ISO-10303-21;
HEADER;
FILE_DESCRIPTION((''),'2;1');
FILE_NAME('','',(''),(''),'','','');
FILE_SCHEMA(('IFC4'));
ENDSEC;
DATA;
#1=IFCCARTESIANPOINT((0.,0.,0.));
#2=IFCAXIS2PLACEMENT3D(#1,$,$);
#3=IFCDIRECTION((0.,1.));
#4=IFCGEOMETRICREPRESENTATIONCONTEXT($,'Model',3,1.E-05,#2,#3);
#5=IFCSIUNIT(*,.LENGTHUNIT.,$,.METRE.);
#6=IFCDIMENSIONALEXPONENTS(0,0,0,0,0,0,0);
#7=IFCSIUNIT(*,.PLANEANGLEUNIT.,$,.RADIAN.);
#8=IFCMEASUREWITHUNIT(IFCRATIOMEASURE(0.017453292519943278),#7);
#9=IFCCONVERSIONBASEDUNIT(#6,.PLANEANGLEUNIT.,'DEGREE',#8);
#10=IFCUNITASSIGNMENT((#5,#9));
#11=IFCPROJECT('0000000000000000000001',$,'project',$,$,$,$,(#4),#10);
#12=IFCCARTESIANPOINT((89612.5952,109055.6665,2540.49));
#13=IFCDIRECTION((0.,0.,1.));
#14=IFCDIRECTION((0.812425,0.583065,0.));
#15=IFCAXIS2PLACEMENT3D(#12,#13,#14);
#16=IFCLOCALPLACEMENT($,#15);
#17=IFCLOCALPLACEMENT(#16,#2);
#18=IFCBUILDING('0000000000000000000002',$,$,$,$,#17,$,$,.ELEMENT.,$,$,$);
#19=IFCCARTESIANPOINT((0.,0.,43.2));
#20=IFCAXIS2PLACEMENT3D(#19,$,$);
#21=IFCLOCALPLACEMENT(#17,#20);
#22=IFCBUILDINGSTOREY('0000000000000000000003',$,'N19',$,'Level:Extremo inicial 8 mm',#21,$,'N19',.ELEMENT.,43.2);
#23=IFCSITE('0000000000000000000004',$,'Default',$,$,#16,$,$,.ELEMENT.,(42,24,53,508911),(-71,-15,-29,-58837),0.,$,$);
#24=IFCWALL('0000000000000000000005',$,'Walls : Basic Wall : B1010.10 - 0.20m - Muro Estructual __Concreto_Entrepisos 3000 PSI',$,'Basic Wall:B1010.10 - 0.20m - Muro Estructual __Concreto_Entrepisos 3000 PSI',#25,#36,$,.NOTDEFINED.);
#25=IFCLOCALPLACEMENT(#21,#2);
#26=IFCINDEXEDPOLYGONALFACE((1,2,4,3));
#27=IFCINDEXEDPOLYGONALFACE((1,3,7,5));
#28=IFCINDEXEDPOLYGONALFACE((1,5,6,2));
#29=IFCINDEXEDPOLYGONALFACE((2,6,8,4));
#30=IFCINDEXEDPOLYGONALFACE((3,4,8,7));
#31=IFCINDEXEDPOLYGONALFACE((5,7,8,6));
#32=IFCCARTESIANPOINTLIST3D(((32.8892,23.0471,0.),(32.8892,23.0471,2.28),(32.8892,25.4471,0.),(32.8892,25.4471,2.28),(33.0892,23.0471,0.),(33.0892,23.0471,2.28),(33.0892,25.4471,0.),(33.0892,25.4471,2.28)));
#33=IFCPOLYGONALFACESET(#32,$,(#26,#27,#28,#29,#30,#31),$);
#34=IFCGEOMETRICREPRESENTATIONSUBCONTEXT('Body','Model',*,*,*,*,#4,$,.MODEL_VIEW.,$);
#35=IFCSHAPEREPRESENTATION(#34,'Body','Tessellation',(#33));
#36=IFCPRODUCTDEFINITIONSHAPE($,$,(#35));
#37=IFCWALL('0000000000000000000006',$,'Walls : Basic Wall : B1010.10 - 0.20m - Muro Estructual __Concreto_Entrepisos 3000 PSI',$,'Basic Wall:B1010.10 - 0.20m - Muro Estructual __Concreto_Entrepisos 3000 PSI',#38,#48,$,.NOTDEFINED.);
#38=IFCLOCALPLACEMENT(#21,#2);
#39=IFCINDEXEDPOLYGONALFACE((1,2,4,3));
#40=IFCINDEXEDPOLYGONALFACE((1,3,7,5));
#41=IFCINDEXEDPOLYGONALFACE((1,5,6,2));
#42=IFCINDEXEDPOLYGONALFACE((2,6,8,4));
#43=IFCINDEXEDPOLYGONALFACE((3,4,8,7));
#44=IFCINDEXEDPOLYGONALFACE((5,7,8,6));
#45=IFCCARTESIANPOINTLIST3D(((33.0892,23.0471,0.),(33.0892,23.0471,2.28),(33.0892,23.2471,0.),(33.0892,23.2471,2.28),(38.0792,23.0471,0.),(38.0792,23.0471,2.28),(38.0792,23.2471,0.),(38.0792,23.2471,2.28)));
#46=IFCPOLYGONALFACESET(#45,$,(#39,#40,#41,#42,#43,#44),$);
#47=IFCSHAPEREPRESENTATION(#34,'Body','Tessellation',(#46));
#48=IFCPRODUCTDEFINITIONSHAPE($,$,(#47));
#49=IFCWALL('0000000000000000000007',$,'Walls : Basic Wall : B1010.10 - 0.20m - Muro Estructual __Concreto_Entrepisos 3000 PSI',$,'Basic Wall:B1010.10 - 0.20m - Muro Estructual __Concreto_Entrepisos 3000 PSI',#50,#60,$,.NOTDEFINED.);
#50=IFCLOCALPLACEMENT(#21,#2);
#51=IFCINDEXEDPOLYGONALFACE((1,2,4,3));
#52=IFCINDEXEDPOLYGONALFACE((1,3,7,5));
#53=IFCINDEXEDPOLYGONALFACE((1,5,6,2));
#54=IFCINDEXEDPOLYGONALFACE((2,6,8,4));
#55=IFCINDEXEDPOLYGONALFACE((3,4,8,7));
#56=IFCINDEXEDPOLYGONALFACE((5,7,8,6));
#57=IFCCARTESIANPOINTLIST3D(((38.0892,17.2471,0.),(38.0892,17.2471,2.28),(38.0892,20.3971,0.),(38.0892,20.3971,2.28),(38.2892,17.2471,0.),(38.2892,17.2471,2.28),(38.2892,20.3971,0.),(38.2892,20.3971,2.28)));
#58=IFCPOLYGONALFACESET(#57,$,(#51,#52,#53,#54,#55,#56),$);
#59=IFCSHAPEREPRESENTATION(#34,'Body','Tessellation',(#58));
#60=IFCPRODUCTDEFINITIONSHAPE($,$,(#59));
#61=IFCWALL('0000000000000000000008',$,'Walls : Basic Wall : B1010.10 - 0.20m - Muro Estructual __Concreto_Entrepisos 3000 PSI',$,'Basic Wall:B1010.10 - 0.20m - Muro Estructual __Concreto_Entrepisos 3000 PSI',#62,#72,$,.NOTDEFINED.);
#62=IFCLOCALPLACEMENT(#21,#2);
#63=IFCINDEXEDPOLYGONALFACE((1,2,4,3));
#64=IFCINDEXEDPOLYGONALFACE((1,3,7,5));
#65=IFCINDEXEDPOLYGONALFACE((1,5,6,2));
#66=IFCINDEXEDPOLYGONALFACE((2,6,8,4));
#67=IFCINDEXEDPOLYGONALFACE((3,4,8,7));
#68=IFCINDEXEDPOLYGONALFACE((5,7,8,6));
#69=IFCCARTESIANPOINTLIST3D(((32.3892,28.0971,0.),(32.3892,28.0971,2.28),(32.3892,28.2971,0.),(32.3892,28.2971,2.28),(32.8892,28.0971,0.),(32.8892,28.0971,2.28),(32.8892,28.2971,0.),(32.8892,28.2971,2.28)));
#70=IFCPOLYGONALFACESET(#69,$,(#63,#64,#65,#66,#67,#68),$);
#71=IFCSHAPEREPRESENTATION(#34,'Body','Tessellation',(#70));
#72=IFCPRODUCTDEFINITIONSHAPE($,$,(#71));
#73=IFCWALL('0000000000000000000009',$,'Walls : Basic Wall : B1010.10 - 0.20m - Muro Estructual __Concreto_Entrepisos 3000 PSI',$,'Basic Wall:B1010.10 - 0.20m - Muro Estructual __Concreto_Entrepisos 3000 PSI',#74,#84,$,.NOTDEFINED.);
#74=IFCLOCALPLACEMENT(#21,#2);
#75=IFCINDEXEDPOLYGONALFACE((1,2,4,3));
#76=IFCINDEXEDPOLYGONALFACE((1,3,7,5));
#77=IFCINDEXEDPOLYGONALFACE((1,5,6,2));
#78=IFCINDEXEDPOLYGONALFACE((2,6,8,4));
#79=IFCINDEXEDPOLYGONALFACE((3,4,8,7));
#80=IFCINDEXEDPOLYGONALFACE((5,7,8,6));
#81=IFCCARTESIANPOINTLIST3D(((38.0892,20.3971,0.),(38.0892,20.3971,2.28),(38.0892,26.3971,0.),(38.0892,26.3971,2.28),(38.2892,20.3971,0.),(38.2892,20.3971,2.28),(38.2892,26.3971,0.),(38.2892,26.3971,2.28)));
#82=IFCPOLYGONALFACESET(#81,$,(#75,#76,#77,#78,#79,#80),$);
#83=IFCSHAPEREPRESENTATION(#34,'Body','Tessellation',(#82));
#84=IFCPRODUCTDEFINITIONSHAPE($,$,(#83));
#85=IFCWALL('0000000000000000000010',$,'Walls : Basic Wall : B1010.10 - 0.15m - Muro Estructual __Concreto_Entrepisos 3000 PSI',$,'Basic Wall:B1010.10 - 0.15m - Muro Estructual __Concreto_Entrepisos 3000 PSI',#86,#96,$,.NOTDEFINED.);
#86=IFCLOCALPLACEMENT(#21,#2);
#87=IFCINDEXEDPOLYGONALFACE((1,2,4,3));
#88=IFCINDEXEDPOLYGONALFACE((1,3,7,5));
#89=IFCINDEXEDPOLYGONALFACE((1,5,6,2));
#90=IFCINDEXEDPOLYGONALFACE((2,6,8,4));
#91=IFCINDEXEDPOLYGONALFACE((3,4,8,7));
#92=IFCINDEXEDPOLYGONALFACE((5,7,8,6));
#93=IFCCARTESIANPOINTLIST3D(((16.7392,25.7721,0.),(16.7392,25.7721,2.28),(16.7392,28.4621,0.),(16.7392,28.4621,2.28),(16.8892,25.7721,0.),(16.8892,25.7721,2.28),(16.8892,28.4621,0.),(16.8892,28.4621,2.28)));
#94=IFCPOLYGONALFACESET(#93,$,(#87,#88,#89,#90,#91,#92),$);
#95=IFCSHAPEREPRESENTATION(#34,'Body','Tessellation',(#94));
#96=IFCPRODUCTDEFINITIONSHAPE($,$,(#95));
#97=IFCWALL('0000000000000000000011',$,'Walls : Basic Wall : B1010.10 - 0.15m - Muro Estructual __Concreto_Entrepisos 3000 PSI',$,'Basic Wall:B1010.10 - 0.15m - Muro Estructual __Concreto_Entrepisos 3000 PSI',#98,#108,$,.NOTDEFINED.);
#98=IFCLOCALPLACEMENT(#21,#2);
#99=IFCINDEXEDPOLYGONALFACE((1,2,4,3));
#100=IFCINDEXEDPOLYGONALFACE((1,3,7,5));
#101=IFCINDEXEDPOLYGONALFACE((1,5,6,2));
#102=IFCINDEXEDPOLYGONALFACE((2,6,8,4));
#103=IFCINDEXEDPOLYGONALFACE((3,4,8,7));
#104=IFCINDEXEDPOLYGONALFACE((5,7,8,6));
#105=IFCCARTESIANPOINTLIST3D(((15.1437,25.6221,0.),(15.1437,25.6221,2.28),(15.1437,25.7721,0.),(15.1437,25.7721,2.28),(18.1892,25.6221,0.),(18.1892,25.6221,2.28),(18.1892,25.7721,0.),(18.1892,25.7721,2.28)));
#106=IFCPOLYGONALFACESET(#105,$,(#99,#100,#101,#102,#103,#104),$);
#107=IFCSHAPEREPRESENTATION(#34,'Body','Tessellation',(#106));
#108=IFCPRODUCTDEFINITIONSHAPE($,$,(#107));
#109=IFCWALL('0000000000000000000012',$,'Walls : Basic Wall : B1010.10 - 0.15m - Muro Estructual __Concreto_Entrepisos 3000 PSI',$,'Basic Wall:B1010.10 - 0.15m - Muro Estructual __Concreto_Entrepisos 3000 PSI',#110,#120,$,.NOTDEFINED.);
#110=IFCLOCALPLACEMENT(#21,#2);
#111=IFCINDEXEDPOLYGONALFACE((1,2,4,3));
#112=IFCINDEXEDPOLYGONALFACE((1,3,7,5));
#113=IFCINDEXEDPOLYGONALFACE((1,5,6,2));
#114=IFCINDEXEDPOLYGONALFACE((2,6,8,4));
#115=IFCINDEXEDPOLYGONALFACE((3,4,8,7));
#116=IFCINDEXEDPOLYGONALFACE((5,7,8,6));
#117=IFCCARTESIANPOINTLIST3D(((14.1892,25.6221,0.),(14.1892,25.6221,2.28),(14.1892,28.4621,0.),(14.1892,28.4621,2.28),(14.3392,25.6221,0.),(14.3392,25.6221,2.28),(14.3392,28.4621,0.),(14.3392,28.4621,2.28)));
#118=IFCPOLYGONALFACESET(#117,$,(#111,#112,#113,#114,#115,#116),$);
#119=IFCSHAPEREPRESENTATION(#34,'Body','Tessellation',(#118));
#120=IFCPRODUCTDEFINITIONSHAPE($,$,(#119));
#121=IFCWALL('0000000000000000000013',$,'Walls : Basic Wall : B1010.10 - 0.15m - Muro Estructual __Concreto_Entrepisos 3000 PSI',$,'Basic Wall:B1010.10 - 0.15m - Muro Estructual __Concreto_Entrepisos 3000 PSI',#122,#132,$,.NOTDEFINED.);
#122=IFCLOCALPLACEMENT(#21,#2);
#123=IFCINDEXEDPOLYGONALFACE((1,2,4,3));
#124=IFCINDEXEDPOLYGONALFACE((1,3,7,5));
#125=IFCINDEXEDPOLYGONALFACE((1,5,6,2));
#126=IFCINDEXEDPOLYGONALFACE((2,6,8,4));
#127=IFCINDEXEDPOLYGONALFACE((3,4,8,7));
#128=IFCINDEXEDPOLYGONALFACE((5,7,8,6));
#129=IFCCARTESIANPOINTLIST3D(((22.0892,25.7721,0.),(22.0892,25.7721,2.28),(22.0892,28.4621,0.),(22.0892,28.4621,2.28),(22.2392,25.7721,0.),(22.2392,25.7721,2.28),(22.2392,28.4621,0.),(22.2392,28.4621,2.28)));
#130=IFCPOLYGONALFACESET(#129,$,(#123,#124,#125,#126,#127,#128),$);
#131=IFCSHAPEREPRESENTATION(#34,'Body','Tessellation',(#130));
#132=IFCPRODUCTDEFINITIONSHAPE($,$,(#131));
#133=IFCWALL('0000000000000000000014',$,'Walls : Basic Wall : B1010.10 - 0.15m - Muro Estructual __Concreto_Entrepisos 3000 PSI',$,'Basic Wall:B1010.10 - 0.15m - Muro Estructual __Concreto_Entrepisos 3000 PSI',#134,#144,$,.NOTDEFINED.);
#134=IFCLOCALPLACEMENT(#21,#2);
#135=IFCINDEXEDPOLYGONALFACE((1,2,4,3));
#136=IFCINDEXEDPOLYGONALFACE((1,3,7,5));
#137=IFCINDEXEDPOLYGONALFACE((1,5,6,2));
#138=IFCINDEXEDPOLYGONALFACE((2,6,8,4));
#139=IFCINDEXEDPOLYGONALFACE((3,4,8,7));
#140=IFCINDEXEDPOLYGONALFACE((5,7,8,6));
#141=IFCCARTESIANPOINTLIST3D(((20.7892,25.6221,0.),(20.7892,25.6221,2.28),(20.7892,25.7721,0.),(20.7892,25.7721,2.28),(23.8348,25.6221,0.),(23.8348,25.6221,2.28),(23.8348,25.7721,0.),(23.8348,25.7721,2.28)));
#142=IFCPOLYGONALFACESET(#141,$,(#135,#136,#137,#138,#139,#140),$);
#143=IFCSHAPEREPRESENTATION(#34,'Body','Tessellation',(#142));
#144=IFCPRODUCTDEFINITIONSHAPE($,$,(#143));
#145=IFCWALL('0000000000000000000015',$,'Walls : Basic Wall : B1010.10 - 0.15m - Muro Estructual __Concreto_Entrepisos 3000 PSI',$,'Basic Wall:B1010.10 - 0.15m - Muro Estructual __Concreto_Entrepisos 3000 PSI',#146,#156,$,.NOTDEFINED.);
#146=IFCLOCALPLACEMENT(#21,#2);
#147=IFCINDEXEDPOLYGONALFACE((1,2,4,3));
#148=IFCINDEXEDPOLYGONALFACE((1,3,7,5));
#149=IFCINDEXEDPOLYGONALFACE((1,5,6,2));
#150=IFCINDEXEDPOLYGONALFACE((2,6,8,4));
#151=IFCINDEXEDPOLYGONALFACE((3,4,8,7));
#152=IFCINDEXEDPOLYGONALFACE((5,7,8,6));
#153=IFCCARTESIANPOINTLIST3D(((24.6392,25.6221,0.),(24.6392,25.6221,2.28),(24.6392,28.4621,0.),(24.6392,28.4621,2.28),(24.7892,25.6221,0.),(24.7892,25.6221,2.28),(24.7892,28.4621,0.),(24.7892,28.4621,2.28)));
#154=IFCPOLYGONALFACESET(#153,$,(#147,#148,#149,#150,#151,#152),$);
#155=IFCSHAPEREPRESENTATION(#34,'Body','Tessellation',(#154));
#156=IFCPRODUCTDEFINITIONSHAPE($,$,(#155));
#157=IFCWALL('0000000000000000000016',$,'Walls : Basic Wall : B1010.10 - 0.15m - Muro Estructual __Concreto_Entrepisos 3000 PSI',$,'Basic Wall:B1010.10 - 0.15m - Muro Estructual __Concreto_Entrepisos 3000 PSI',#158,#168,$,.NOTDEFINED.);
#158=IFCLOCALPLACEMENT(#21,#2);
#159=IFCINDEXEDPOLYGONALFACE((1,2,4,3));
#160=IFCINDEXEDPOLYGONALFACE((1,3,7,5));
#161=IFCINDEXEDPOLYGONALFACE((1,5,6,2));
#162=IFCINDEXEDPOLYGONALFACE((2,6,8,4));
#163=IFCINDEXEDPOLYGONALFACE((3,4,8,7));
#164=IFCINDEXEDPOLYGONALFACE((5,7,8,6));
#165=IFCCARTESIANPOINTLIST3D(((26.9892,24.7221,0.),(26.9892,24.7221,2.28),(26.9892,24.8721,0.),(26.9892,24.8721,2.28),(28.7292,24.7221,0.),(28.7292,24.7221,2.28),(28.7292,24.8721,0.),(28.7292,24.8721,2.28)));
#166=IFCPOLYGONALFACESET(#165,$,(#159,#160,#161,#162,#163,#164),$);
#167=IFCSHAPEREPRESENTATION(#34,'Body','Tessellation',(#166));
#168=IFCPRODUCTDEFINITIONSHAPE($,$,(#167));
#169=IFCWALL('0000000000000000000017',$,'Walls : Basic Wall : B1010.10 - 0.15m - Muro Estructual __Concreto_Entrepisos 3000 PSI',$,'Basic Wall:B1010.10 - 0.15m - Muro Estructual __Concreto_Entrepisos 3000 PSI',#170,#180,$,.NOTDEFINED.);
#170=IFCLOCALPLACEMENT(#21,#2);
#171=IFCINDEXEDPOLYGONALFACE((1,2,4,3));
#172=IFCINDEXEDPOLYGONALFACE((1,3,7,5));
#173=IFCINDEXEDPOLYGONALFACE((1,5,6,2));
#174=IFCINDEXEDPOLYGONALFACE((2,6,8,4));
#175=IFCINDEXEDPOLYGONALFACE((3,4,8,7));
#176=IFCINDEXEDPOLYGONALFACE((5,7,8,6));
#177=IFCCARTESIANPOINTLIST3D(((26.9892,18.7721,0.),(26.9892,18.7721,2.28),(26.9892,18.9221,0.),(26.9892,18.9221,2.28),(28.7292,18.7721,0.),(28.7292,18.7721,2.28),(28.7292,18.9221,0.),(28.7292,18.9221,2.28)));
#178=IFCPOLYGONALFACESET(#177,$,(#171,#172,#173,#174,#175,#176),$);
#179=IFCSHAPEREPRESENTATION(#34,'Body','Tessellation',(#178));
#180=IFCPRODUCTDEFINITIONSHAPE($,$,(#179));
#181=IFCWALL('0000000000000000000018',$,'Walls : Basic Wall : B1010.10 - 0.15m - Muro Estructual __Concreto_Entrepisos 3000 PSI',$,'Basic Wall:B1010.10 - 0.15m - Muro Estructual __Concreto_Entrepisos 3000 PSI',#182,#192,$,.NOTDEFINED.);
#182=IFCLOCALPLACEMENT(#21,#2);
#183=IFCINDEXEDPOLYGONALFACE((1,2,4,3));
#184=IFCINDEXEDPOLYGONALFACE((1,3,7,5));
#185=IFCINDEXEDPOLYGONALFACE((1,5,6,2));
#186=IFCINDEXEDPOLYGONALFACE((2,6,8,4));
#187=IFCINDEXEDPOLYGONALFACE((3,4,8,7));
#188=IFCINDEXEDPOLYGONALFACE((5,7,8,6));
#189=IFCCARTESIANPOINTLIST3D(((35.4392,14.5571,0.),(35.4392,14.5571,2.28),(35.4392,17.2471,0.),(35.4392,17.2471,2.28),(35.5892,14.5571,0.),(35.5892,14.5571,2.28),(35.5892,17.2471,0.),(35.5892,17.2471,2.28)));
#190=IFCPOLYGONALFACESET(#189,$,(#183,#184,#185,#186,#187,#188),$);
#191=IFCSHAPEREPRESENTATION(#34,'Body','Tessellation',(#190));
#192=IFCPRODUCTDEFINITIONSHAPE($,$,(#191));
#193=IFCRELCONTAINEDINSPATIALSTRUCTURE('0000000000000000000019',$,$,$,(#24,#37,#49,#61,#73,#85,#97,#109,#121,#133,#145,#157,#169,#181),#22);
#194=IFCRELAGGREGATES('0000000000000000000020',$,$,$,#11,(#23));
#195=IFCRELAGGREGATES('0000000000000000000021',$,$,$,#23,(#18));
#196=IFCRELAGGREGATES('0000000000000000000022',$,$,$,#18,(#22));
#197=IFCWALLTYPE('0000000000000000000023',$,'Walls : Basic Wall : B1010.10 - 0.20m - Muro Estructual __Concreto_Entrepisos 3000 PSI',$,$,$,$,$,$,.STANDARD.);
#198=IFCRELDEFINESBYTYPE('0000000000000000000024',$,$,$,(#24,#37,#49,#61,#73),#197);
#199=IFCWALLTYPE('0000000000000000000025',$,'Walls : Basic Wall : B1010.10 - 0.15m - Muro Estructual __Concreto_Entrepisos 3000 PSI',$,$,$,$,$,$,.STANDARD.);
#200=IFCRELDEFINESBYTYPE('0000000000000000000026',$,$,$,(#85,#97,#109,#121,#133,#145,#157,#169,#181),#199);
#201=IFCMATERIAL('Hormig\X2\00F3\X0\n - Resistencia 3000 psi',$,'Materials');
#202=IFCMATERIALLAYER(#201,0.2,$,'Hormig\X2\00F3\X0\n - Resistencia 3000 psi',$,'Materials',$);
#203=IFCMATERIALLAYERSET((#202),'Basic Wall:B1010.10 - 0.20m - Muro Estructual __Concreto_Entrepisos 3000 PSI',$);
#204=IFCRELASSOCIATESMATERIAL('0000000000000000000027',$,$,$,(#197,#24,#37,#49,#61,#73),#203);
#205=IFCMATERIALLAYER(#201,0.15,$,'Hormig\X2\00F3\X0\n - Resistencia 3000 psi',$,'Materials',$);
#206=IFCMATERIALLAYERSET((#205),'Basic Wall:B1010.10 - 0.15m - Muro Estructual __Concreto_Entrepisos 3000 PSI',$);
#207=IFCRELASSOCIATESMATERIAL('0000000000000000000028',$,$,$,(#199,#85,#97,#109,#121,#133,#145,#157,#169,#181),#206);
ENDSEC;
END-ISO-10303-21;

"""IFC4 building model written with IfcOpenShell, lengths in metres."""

from ifc_helpers import new_model, entity, si_unit, converted_unit, direction, frame, frame_2d, origin, place, context, subcontext, project, spatial, rectangle, extrude, material, layer, layer_set, layer_usage, type_object, element, save


model = new_model("IFC4")

# Units and contexts
model_context = context("Model", 3, precision=1e-05, world=origin(), true_north=direction((0.0, 1.0)))
body_context = subcontext(model_context, "Body", "Model", "MODEL_VIEW")
ifc_project = project(units=[si_unit("LENGTHUNIT", "METRE"), converted_unit("PLANEANGLEUNIT", "DEGREE", entity("IfcRatioMeasure", 0.017453292519943278), si_unit("PLANEANGLEUNIT", "RADIAN"), dimensions=[0, 0, 0, 0, 0, 0, 0])], contexts=[model_context])

# Site, building, storey
site_placement = place(None, frame((89612.5952, 109055.6665, 2540.49), z_axis=(0.0, 0.0, 1.0), x_axis=(0.812425, 0.583065, 0.0)))
site = spatial("IfcSite", under=ifc_project, at=site_placement, Name="Default", CompositionType="ELEMENT", RefLatitude=(42, 24, 53, 508911), RefLongitude=(-71, -15, -29, -58837), RefElevation=0.0)
building_placement = place(site_placement, origin())
building = spatial("IfcBuilding", under=site, at=building_placement, CompositionType="ELEMENT")
storey_placement = place(building_placement, frame((0.0, 0.0, 43.2)))
storey = spatial("IfcBuildingStorey", under=building, at=storey_placement, Name="N19", ObjectType="Level:Extremo inicial 8 mm", LongName="N19", CompositionType="ELEMENT", Elevation=43.2)

# Walls
ifc_material = material(Name="Hormigón - Resistencia 3000 psi", Category="Materials")
ifc_layer_1 = layer(ifc_material, 0.2, Name="Hormigón - Resistencia 3000 psi", Category="Materials")
ifc_layer_set_1 = layer_set([ifc_layer_1], Name="Basic Wall:B1010.10 - 0.20m - Muro Estructual __Concreto_Entrepisos 3000 PSI")
wall_type_1 = type_object("IfcWallType", Name="Walls : Basic Wall : B1010.10 - 0.20m - Muro Estructual __Concreto_Entrepisos 3000 PSI", PredefinedType="STANDARD", material=ifc_layer_set_1)
ifc_layer_usage_1 = layer_usage(ifc_layer_set_1, "AXIS2", "POSITIVE", -0.1)
wall_1_placement = place(storey_placement, frame((32.9892, 25.4471, 0.0), z_axis=(0.0, 0.0, 1.0), x_axis=(0.0, -1.0, 0.0)))
element("IfcWall", 1, at=wall_1_placement, inside=storey, type_object=wall_type_1, material=ifc_layer_usage_1, Name="Walls : Basic Wall : B1010.10 - 0.20m - Muro Estructual __Concreto_Entrepisos 3000 PSI", ObjectType="Basic Wall:B1010.10 - 0.20m - Muro Estructual __Concreto_Entrepisos 3000 PSI", PredefinedType="NOTDEFINED", context=body_context, shape_type="SweptSolid", body=[
    extrude(rectangle(XDim=2.4, YDim=0.2, at=frame_2d((1.2, 0.0), x_axis=(-1.0, 0.0))), origin(), (0.0, 0.0, 1.0), 2.28),
])
ifc_layer_usage_2 = layer_usage(ifc_layer_set_1, "AXIS2", "POSITIVE", -0.1)
wall_2_placement = place(storey_placement, frame((33.0892, 23.1471, 0.0)))
element("IfcWall", 2, at=wall_2_placement, inside=storey, type_object=wall_type_1, material=ifc_layer_usage_2, Name="Walls : Basic Wall : B1010.10 - 0.20m - Muro Estructual __Concreto_Entrepisos 3000 PSI", ObjectType="Basic Wall:B1010.10 - 0.20m - Muro Estructual __Concreto_Entrepisos 3000 PSI", PredefinedType="NOTDEFINED", context=body_context, shape_type="SweptSolid", body=[
    extrude(rectangle(XDim=4.99, YDim=0.2, at=frame_2d((2.495, 0.0), x_axis=(-1.0, 0.0))), origin(), (0.0, 0.0, 1.0), 2.28),
])
ifc_layer_usage_3 = layer_usage(ifc_layer_set_1, "AXIS2", "POSITIVE", -0.1)
wall_3_placement = place(storey_placement, frame((38.1892, 17.2471, 0.0), z_axis=(0.0, 0.0, 1.0), x_axis=(0.0, 1.0, 0.0)))
element("IfcWall", 3, at=wall_3_placement, inside=storey, type_object=wall_type_1, material=ifc_layer_usage_3, Name="Walls : Basic Wall : B1010.10 - 0.20m - Muro Estructual __Concreto_Entrepisos 3000 PSI", ObjectType="Basic Wall:B1010.10 - 0.20m - Muro Estructual __Concreto_Entrepisos 3000 PSI", PredefinedType="NOTDEFINED", context=body_context, shape_type="SweptSolid", body=[
    extrude(rectangle(XDim=3.15, YDim=0.2, at=frame_2d((1.575, 0.0), x_axis=(-1.0, 0.0))), origin(), (0.0, 0.0, 1.0), 2.28),
])
ifc_layer_usage_4 = layer_usage(ifc_layer_set_1, "AXIS2", "POSITIVE", -0.1)
wall_4_placement = place(storey_placement, frame((32.3892, 28.1971, 0.0)))
element("IfcWall", 4, at=wall_4_placement, inside=storey, type_object=wall_type_1, material=ifc_layer_usage_4, Name="Walls : Basic Wall : B1010.10 - 0.20m - Muro Estructual __Concreto_Entrepisos 3000 PSI", ObjectType="Basic Wall:B1010.10 - 0.20m - Muro Estructual __Concreto_Entrepisos 3000 PSI", PredefinedType="NOTDEFINED", context=body_context, shape_type="SweptSolid", body=[
    extrude(rectangle(XDim=0.5, YDim=0.2, at=frame_2d((0.25, 0.0), x_axis=(-1.0, 0.0))), origin(), (0.0, 0.0, 1.0), 2.28),
])
ifc_layer_usage_5 = layer_usage(ifc_layer_set_1, "AXIS2", "POSITIVE", -0.1)
wall_5_placement = place(storey_placement, frame((38.1892, 20.3971, 0.0), z_axis=(0.0, 0.0, 1.0), x_axis=(0.0, 1.0, 0.0)))
element("IfcWall", 5, at=wall_5_placement, inside=storey, type_object=wall_type_1, material=ifc_layer_usage_5, Name="Walls : Basic Wall : B1010.10 - 0.20m - Muro Estructual __Concreto_Entrepisos 3000 PSI", ObjectType="Basic Wall:B1010.10 - 0.20m - Muro Estructual __Concreto_Entrepisos 3000 PSI", PredefinedType="NOTDEFINED", context=body_context, shape_type="SweptSolid", body=[
    extrude(rectangle(XDim=6.0, YDim=0.2, at=frame_2d((3.0, 0.0), x_axis=(-1.0, 0.0))), origin(), (0.0, 0.0, 1.0), 2.28),
])
ifc_layer_2 = layer(ifc_material, 0.15, Name="Hormigón - Resistencia 3000 psi", Category="Materials")
ifc_layer_set_2 = layer_set([ifc_layer_2], Name="Basic Wall:B1010.10 - 0.15m - Muro Estructual __Concreto_Entrepisos 3000 PSI")
ifc_layer_usage_6 = layer_usage(ifc_layer_set_2, "AXIS2", "POSITIVE", -0.075)
wall_type_2 = type_object("IfcWallType", Name="Walls : Basic Wall : B1010.10 - 0.15m - Muro Estructual __Concreto_Entrepisos 3000 PSI", PredefinedType="STANDARD", material=ifc_layer_set_2)
wall_6_placement = place(storey_placement, frame((16.8142, 28.4621, 0.0), z_axis=(0.0, 0.0, 1.0), x_axis=(0.0, -1.0, 0.0)))
element("IfcWall", 6, at=wall_6_placement, inside=storey, type_object=wall_type_2, material=ifc_layer_usage_6, Name="Walls : Basic Wall : B1010.10 - 0.15m - Muro Estructual __Concreto_Entrepisos 3000 PSI", ObjectType="Basic Wall:B1010.10 - 0.15m - Muro Estructual __Concreto_Entrepisos 3000 PSI", PredefinedType="NOTDEFINED", context=body_context, shape_type="SweptSolid", body=[
    extrude(rectangle(XDim=2.69, YDim=0.15, at=frame_2d((1.345, 0.0), x_axis=(-1.0, 0.0))), origin(), (0.0, 0.0, 1.0), 2.28),
])
ifc_layer_usage_7 = layer_usage(ifc_layer_set_2, "AXIS2", "POSITIVE", -0.075)
wall_7_placement = place(storey_placement, frame((18.1892, 25.6971, 0.0), z_axis=(0.0, 0.0, 1.0), x_axis=(-1.0, 0.0, 0.0)))
element("IfcWall", 7, at=wall_7_placement, inside=storey, type_object=wall_type_2, material=ifc_layer_usage_7, Name="Walls : Basic Wall : B1010.10 - 0.15m - Muro Estructual __Concreto_Entrepisos 3000 PSI", ObjectType="Basic Wall:B1010.10 - 0.15m - Muro Estructual __Concreto_Entrepisos 3000 PSI", PredefinedType="NOTDEFINED", context=body_context, shape_type="SweptSolid", body=[
    extrude(rectangle(XDim=3.0455, YDim=0.15, at=frame_2d((1.5228, 0.0), x_axis=(-1.0, 0.0))), origin(), (0.0, 0.0, 1.0), 2.28),
])
ifc_layer_usage_8 = layer_usage(ifc_layer_set_2, "AXIS2", "POSITIVE", -0.075)
wall_8_placement = place(storey_placement, frame((14.2642, 28.4621, 0.0), z_axis=(0.0, 0.0, 1.0), x_axis=(0.0, -1.0, 0.0)))
element("IfcWall", 8, at=wall_8_placement, inside=storey, type_object=wall_type_2, material=ifc_layer_usage_8, Name="Walls : Basic Wall : B1010.10 - 0.15m - Muro Estructual __Concreto_Entrepisos 3000 PSI", ObjectType="Basic Wall:B1010.10 - 0.15m - Muro Estructual __Concreto_Entrepisos 3000 PSI", PredefinedType="NOTDEFINED", context=body_context, shape_type="SweptSolid", body=[
    extrude(rectangle(XDim=2.84, YDim=0.15, at=frame_2d((1.42, 0.0), x_axis=(-1.0, 0.0))), origin(), (0.0, 0.0, 1.0), 2.28),
])
ifc_layer_usage_9 = layer_usage(ifc_layer_set_2, "AXIS2", "NEGATIVE", 0.075)
wall_9_placement = place(storey_placement, frame((22.1642, 28.4621, 0.0), z_axis=(0.0, 0.0, 1.0), x_axis=(0.0, -1.0, 0.0)))
element("IfcWall", 9, at=wall_9_placement, inside=storey, type_object=wall_type_2, material=ifc_layer_usage_9, Name="Walls : Basic Wall : B1010.10 - 0.15m - Muro Estructual __Concreto_Entrepisos 3000 PSI", ObjectType="Basic Wall:B1010.10 - 0.15m - Muro Estructual __Concreto_Entrepisos 3000 PSI", PredefinedType="NOTDEFINED", context=body_context, shape_type="SweptSolid", body=[
    extrude(rectangle(XDim=2.69, YDim=0.15, at=frame_2d((1.345, 0.0), x_axis=(-1.0, 0.0))), origin(), (0.0, 0.0, 1.0), 2.28),
])
ifc_layer_usage_10 = layer_usage(ifc_layer_set_2, "AXIS2", "NEGATIVE", 0.075)
wall_10_placement = place(storey_placement, frame((20.7892, 25.6971, 0.0)))
element("IfcWall", 10, at=wall_10_placement, inside=storey, type_object=wall_type_2, material=ifc_layer_usage_10, Name="Walls : Basic Wall : B1010.10 - 0.15m - Muro Estructual __Concreto_Entrepisos 3000 PSI", ObjectType="Basic Wall:B1010.10 - 0.15m - Muro Estructual __Concreto_Entrepisos 3000 PSI", PredefinedType="NOTDEFINED", context=body_context, shape_type="SweptSolid", body=[
    extrude(rectangle(XDim=3.0455, YDim=0.15, at=frame_2d((1.5228, 0.0), x_axis=(-1.0, 0.0))), origin(), (0.0, 0.0, 1.0), 2.28),
])
ifc_layer_usage_11 = layer_usage(ifc_layer_set_2, "AXIS2", "NEGATIVE", 0.075)
wall_11_placement = place(storey_placement, frame((24.7142, 28.4621, 0.0), z_axis=(0.0, 0.0, 1.0), x_axis=(0.0, -1.0, 0.0)))
element("IfcWall", 11, at=wall_11_placement, inside=storey, type_object=wall_type_2, material=ifc_layer_usage_11, Name="Walls : Basic Wall : B1010.10 - 0.15m - Muro Estructual __Concreto_Entrepisos 3000 PSI", ObjectType="Basic Wall:B1010.10 - 0.15m - Muro Estructual __Concreto_Entrepisos 3000 PSI", PredefinedType="NOTDEFINED", context=body_context, shape_type="SweptSolid", body=[
    extrude(rectangle(XDim=2.84, YDim=0.15, at=frame_2d((1.42, 0.0), x_axis=(-1.0, 0.0))), origin(), (0.0, 0.0, 1.0), 2.28),
])
ifc_layer_usage_12 = layer_usage(ifc_layer_set_2, "AXIS2", "NEGATIVE", 0.075)
wall_12_placement = place(storey_placement, frame((26.9892, 24.7971, 0.0)))
element("IfcWall", 12, at=wall_12_placement, inside=storey, type_object=wall_type_2, material=ifc_layer_usage_12, Name="Walls : Basic Wall : B1010.10 - 0.15m - Muro Estructual __Concreto_Entrepisos 3000 PSI", ObjectType="Basic Wall:B1010.10 - 0.15m - Muro Estructual __Concreto_Entrepisos 3000 PSI", PredefinedType="NOTDEFINED", context=body_context, shape_type="SweptSolid", body=[
    extrude(rectangle(XDim=1.74, YDim=0.15, at=frame_2d((0.87, 0.0), x_axis=(-1.0, 0.0))), origin(), (0.0, 0.0, 1.0), 2.28),
])
ifc_layer_usage_13 = layer_usage(ifc_layer_set_2, "AXIS2", "POSITIVE", -0.075)
wall_13_placement = place(storey_placement, frame((26.9892, 18.8471, 0.0)))
element("IfcWall", 13, at=wall_13_placement, inside=storey, type_object=wall_type_2, material=ifc_layer_usage_13, Name="Walls : Basic Wall : B1010.10 - 0.15m - Muro Estructual __Concreto_Entrepisos 3000 PSI", ObjectType="Basic Wall:B1010.10 - 0.15m - Muro Estructual __Concreto_Entrepisos 3000 PSI", PredefinedType="NOTDEFINED", context=body_context, shape_type="SweptSolid", body=[
    extrude(rectangle(XDim=1.74, YDim=0.15, at=frame_2d((0.87, 0.0), x_axis=(-1.0, 0.0))), origin(), (0.0, 0.0, 1.0), 2.28),
])
ifc_layer_usage_14 = layer_usage(ifc_layer_set_2, "AXIS2", "NEGATIVE", 0.075)
wall_14_placement = place(storey_placement, frame((35.5142, 14.5571, 0.0), z_axis=(0.0, 0.0, 1.0), x_axis=(0.0, 1.0, 0.0)))
element("IfcWall", 14, at=wall_14_placement, inside=storey, type_object=wall_type_2, material=ifc_layer_usage_14, Name="Walls : Basic Wall : B1010.10 - 0.15m - Muro Estructual __Concreto_Entrepisos 3000 PSI", ObjectType="Basic Wall:B1010.10 - 0.15m - Muro Estructual __Concreto_Entrepisos 3000 PSI", PredefinedType="NOTDEFINED", context=body_context, shape_type="SweptSolid", body=[
    extrude(rectangle(XDim=2.69, YDim=0.15, at=frame_2d((1.345, 0.0), x_axis=(-1.0, 0.0))), origin(), (0.0, 0.0, 1.0), 2.28),
])

save(model, "model.ifc")
